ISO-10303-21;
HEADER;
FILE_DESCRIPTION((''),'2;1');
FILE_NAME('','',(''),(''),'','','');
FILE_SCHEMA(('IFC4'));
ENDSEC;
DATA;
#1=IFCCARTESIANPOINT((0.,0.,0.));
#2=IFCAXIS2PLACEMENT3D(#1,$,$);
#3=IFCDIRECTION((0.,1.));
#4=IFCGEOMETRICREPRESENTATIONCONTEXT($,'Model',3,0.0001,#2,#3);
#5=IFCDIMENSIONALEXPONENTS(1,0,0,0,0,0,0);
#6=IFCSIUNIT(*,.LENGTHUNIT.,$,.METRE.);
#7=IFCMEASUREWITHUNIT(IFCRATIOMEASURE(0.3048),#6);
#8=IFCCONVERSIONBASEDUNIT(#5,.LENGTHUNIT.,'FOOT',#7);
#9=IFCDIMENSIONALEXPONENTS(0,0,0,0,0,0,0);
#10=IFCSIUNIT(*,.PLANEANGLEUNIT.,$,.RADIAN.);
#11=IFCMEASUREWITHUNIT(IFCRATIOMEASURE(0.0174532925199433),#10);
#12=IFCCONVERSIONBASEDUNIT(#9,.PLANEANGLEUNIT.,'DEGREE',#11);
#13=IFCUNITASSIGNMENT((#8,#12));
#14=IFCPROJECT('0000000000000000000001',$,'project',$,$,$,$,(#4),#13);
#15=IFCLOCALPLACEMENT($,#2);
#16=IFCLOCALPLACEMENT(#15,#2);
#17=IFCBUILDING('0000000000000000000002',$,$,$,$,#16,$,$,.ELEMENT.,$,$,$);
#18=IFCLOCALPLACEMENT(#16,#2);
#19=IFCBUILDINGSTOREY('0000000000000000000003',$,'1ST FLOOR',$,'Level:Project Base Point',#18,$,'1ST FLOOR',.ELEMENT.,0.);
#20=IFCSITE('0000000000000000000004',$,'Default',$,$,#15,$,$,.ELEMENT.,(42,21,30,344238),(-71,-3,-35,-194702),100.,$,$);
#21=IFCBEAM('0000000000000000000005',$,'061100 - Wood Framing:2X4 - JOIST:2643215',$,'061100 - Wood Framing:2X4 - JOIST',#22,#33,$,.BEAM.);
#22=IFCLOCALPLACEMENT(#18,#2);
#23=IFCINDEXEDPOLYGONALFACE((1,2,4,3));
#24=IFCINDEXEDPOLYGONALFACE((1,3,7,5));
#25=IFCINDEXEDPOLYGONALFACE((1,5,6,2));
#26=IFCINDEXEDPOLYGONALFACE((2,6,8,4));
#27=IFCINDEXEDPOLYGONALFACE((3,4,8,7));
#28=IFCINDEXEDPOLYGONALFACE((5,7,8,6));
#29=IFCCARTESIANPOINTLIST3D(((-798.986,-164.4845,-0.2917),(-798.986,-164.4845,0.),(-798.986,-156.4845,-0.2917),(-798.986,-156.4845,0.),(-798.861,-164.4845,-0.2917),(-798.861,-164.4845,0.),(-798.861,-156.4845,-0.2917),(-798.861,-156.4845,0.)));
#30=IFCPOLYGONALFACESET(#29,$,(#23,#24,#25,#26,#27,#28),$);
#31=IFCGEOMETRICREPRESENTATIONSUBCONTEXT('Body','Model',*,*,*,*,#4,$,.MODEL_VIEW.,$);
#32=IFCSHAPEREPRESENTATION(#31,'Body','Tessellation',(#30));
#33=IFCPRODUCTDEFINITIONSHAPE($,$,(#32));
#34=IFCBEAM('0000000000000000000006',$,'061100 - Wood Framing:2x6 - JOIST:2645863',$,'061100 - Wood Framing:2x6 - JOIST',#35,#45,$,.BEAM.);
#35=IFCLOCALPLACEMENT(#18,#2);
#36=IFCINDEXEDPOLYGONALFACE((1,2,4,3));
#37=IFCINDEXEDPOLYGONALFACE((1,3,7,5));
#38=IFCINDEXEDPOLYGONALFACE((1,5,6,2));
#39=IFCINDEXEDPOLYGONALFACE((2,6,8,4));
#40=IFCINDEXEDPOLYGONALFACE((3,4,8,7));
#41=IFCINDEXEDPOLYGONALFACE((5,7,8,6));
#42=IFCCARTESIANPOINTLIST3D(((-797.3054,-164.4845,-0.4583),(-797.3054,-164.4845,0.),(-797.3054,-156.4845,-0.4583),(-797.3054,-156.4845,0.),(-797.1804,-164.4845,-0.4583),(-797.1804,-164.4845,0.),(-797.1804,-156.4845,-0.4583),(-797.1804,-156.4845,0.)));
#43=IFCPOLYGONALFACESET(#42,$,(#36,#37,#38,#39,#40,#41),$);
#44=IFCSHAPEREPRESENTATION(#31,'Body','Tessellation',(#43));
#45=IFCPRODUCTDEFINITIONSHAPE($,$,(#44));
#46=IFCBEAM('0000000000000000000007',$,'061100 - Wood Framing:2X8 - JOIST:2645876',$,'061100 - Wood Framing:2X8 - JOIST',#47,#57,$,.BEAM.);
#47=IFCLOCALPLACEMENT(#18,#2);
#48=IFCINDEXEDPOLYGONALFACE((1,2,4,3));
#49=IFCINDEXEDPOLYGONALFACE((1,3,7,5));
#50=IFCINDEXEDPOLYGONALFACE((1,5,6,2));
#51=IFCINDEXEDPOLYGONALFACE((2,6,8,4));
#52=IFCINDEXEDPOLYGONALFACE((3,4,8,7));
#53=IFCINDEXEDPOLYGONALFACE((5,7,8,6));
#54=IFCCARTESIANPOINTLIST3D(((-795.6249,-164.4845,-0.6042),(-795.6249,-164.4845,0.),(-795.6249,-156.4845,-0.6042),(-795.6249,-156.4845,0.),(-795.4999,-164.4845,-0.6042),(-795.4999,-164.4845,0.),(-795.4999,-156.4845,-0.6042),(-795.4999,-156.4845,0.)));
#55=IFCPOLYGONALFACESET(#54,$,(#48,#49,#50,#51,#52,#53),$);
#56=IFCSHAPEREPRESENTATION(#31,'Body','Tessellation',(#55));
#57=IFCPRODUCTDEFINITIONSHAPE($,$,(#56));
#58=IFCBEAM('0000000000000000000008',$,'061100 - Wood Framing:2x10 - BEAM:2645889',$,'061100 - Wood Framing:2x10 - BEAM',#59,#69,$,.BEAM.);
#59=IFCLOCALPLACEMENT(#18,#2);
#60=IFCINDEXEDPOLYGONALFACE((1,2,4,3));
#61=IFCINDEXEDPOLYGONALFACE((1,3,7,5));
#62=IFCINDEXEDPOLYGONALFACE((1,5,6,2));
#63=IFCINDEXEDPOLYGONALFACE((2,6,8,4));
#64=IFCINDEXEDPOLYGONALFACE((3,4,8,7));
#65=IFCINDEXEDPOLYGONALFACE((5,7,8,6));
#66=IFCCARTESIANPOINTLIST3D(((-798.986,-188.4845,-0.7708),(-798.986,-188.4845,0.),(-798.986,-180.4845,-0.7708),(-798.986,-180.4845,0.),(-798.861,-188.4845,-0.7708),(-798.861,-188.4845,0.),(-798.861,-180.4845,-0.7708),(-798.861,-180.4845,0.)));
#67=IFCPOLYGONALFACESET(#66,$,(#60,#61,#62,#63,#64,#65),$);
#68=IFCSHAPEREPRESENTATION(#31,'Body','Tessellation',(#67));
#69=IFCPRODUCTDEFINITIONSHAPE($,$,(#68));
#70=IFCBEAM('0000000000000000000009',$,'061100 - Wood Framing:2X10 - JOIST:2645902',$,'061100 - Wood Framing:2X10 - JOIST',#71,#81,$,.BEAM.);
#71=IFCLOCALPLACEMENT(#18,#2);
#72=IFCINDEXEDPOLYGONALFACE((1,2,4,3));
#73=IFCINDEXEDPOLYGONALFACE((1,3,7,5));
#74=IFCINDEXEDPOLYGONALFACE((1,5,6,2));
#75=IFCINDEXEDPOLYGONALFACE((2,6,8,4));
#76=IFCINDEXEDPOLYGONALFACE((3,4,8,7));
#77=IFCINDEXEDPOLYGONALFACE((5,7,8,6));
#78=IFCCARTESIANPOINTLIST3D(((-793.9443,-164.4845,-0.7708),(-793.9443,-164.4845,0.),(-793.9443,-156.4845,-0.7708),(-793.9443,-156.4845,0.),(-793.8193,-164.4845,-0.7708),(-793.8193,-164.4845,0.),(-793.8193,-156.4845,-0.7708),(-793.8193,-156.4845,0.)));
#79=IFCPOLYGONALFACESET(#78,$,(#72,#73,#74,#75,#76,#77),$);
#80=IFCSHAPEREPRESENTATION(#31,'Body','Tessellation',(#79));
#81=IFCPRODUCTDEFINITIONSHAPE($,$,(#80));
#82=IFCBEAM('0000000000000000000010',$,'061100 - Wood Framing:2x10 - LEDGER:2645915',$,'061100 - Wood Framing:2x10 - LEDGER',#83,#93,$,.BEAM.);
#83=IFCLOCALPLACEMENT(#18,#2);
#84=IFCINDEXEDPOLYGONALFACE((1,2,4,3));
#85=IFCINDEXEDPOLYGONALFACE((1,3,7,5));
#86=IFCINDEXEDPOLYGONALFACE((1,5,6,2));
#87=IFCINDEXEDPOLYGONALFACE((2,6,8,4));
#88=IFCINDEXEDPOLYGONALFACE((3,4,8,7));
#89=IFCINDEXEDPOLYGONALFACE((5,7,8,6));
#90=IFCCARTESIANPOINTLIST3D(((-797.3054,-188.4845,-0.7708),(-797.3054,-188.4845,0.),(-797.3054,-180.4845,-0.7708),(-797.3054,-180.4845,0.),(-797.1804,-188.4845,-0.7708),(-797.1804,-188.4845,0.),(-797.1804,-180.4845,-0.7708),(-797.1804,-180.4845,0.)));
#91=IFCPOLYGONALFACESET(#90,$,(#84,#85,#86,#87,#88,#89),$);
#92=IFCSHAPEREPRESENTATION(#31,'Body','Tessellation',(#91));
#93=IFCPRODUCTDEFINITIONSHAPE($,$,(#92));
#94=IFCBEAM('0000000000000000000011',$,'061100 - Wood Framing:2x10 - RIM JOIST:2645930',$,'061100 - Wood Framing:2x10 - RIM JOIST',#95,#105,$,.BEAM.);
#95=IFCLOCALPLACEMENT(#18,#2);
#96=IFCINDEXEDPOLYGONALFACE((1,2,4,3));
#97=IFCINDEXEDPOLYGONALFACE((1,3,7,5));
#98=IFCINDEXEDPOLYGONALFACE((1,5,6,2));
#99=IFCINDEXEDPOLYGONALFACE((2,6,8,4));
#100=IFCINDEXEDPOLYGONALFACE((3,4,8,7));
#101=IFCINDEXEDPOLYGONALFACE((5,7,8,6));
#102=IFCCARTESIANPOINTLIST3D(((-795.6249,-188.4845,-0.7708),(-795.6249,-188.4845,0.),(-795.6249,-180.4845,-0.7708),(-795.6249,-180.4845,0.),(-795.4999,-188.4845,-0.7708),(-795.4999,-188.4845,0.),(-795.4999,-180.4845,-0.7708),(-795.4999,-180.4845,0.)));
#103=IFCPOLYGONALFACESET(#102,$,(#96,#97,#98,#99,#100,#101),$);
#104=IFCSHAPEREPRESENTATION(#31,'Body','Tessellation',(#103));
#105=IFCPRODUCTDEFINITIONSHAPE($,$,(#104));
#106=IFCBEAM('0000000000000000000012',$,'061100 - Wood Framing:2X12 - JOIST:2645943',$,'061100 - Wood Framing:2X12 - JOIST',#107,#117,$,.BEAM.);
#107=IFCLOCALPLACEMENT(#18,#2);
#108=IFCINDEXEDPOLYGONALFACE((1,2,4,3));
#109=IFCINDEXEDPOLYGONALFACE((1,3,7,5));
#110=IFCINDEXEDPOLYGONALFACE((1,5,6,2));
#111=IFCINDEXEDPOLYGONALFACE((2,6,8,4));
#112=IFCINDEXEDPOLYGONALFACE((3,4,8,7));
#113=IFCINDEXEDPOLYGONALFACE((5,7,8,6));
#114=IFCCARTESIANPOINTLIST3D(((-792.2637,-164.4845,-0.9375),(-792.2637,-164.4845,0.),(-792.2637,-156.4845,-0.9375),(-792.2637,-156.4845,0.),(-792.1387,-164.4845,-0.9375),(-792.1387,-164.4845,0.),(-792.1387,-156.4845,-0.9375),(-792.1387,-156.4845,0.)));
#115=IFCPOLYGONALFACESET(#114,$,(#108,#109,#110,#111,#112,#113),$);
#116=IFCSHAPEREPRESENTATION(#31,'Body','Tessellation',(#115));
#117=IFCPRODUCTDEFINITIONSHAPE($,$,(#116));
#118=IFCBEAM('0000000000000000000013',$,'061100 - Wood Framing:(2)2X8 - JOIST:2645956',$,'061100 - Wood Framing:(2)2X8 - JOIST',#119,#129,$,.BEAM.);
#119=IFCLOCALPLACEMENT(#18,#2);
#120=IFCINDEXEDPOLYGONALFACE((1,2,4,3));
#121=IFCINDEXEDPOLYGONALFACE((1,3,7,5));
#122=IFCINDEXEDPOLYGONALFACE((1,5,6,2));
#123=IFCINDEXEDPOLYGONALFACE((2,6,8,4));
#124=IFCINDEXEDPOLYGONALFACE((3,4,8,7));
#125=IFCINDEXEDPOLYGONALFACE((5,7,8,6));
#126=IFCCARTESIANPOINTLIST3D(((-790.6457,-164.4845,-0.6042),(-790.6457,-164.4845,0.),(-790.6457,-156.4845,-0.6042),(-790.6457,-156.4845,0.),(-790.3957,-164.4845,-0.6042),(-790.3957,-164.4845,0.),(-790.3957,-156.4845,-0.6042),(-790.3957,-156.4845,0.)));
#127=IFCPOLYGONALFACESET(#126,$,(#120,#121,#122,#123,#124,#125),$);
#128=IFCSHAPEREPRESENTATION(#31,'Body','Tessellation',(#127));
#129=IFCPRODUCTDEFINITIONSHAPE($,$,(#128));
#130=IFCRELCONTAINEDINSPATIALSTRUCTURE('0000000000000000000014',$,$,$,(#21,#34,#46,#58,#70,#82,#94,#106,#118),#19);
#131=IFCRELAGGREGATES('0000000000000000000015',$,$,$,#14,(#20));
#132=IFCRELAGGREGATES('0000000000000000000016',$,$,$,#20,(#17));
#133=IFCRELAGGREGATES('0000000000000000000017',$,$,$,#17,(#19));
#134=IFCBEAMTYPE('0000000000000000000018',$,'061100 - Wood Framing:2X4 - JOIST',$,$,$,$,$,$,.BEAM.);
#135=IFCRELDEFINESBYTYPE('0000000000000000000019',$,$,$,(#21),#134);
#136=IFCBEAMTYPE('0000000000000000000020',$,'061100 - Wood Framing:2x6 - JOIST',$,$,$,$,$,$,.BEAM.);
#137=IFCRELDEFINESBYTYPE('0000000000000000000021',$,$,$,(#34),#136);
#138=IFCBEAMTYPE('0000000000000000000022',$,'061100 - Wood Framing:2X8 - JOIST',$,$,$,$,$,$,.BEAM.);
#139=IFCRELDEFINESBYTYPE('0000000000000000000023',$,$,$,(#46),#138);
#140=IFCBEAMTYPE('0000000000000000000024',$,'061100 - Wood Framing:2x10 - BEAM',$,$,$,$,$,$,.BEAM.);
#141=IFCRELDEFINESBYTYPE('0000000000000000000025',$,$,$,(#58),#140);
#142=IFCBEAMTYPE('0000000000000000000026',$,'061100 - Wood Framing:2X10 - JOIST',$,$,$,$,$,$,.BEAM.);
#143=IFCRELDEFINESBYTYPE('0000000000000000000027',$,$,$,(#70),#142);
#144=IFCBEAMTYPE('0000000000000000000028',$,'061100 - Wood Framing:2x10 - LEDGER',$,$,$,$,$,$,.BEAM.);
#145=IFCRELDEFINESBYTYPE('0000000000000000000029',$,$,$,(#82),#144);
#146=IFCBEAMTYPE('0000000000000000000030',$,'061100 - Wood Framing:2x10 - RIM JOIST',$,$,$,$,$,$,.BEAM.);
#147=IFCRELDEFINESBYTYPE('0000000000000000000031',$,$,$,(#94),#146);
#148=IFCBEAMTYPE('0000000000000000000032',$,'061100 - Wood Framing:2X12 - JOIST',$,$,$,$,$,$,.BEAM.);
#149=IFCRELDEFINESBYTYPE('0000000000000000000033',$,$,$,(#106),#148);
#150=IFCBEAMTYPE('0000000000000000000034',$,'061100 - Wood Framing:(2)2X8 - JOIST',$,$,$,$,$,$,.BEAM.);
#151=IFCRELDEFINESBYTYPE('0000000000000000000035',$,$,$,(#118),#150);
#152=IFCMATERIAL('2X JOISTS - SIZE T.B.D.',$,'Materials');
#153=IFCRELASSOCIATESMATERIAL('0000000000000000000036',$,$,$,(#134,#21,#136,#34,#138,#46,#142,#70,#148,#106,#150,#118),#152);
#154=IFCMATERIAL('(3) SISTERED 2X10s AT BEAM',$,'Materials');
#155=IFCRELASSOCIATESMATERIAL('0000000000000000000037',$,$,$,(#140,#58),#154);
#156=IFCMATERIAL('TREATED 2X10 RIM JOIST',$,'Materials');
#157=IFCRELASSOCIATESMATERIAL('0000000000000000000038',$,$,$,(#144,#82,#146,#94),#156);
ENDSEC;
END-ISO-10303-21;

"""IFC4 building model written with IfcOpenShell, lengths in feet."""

from ifc_helpers import new_model, entity, si_unit, converted_unit, direction, frame, frame_2d, origin, origin_2d_with_axis, place, context, subcontext, project, spatial, rectangle, extrude, source, transform, mapped, material, material_profile, profile_set, profile_usage, type_object, type_shapes, element, save


model = new_model("IFC4")

# Units and contexts
model_context = context("Model", 3, precision=0.0001, world=origin(), true_north=direction((0.0, 1.0)))
body_context = subcontext(model_context, "Body", "Model", "MODEL_VIEW")
ifc_project = project(units=[converted_unit("LENGTHUNIT", "FOOT", entity("IfcRatioMeasure", 0.3048), si_unit("LENGTHUNIT", "METRE"), dimensions=[1, 0, 0, 0, 0, 0, 0]), converted_unit("PLANEANGLEUNIT", "DEGREE", entity("IfcRatioMeasure", 0.0174532925199433), si_unit("PLANEANGLEUNIT", "RADIAN"), dimensions=[0, 0, 0, 0, 0, 0, 0])], contexts=[model_context])

# Site, building, storey
site_placement = place(None, origin())
site = spatial("IfcSite", under=ifc_project, at=site_placement, Name="Default", CompositionType="ELEMENT", RefLatitude=(42, 21, 30, 344238), RefLongitude=(-71, -3, -35, -194702), RefElevation=100.0)
building_placement = place(site_placement, origin())
building = spatial("IfcBuilding", under=site, at=building_placement, CompositionType="ELEMENT")
storey_placement = place(building_placement, origin())
storey = spatial("IfcBuildingStorey", under=building, at=storey_placement, Name="1ST FLOOR", ObjectType="Level:Project Base Point", LongName="1ST FLOOR", CompositionType="ELEMENT", Elevation=0.0)

# Beams
ifc_material_1 = material(Name="2X JOISTS - SIZE T.B.D.", Category="Materials")
ifc_material_profile_1 = material_profile(ifc_material_1, rectangle(XDim=0.2917, YDim=0.125, at=origin_2d_with_axis()), Name="2X4 - JOIST")
ifc_profile_set_1 = profile_set([ifc_material_profile_1], Name="2X4 - JOIST")
ifc_profile_usage_1 = profile_usage(ifc_profile_set_1, cardinal=8)
beam_type_1 = type_object("IfcBeamType", Name="061100 - Wood Framing:2X4 - JOIST", PredefinedType="BEAM", material=ifc_profile_set_1)
shared_shape_1 = source(origin(), body_context, "Body", "SweptSolid", [
    extrude(rectangle(XDim=0.2917, YDim=0.125, at=origin_2d_with_axis()), frame((-4.0, 0.0, 0.0), z_axis=(1.0, 0.0, 0.0), x_axis=(0.0, 0.0, -1.0)), (0.0, 0.0, 1.0), 8.0),
])
type_shapes(beam_type_1, [shared_shape_1])
beam_1_placement = place(storey_placement, frame((-798.9235, -160.4845, -0.1458), z_axis=(0.0, 0.0, 1.0), x_axis=(0.0, -1.0, 0.0)))
element("IfcBeam", 1, at=beam_1_placement, inside=storey, type_object=beam_type_1, material=ifc_profile_usage_1, Name="061100 - Wood Framing:2X4 - JOIST:2643215", ObjectType="061100 - Wood Framing:2X4 - JOIST", PredefinedType="BEAM", context=body_context, shape_type="MappedRepresentation", body=[
    mapped(shared_shape_1, transform((0.0, 0.0, 0.0), scale=1.0)),
])
ifc_material_profile_2 = material_profile(ifc_material_1, rectangle(XDim=0.4583, YDim=0.125, at=origin_2d_with_axis()), Name="2x6 - JOIST")
ifc_profile_set_2 = profile_set([ifc_material_profile_2], Name="2x6 - JOIST")
ifc_profile_usage_2 = profile_usage(ifc_profile_set_2, cardinal=8)
beam_type_2 = type_object("IfcBeamType", Name="061100 - Wood Framing:2x6 - JOIST", PredefinedType="BEAM", material=ifc_profile_set_2)
shared_shape_2 = source(origin(), body_context, "Body", "SweptSolid", [
    extrude(rectangle(XDim=0.4583, YDim=0.125, at=origin_2d_with_axis()), frame((-4.0, 0.0, 0.0), z_axis=(1.0, 0.0, 0.0), x_axis=(0.0, 0.0, -1.0)), (0.0, 0.0, 1.0), 8.0),
])
type_shapes(beam_type_2, [shared_shape_2])
beam_2_placement = place(storey_placement, frame((-797.2429, -160.4845, -0.2292), z_axis=(0.0, 0.0, 1.0), x_axis=(0.0, -1.0, 0.0)))
element("IfcBeam", 2, at=beam_2_placement, inside=storey, type_object=beam_type_2, material=ifc_profile_usage_2, Name="061100 - Wood Framing:2x6 - JOIST:2645863", ObjectType="061100 - Wood Framing:2x6 - JOIST", PredefinedType="BEAM", context=body_context, shape_type="MappedRepresentation", body=[
    mapped(shared_shape_2, transform((0.0, 0.0, 0.0), scale=1.0)),
])
ifc_material_profile_3 = material_profile(ifc_material_1, rectangle(XDim=0.6042, YDim=0.125, at=origin_2d_with_axis()), Name="2X8 - JOIST")
ifc_profile_set_3 = profile_set([ifc_material_profile_3], Name="2X8 - JOIST")
ifc_profile_usage_3 = profile_usage(ifc_profile_set_3, cardinal=8)
beam_type_3 = type_object("IfcBeamType", Name="061100 - Wood Framing:2X8 - JOIST", PredefinedType="BEAM", material=ifc_profile_set_3)
shared_shape_3 = source(origin(), body_context, "Body", "SweptSolid", [
    extrude(rectangle(XDim=0.6042, YDim=0.125, at=origin_2d_with_axis()), frame((-4.0, 0.0, 0.0), z_axis=(1.0, 0.0, 0.0), x_axis=(0.0, 0.0, -1.0)), (0.0, 0.0, 1.0), 8.0),
])
type_shapes(beam_type_3, [shared_shape_3])
beam_3_placement = place(storey_placement, frame((-795.5624, -160.4845, -0.3021), z_axis=(0.0, 0.0, 1.0), x_axis=(0.0, -1.0, 0.0)))
element("IfcBeam", 3, at=beam_3_placement, inside=storey, type_object=beam_type_3, material=ifc_profile_usage_3, Name="061100 - Wood Framing:2X8 - JOIST:2645876", ObjectType="061100 - Wood Framing:2X8 - JOIST", PredefinedType="BEAM", context=body_context, shape_type="MappedRepresentation", body=[
    mapped(shared_shape_3, transform((0.0, 0.0, 0.0), scale=1.0)),
])
ifc_material_2 = material(Name="(3) SISTERED 2X10s AT BEAM", Category="Materials")
ifc_material_profile_4 = material_profile(ifc_material_2, rectangle(XDim=0.7708, YDim=0.125, at=frame_2d((0.0, 0.0), x_axis=(1.0, 0.0))), Name="2x10 - BEAM")
ifc_profile_set_4 = profile_set([ifc_material_profile_4], Name="2x10 - BEAM")
ifc_profile_usage_4 = profile_usage(ifc_profile_set_4, cardinal=8)
beam_type_4 = type_object("IfcBeamType", Name="061100 - Wood Framing:2x10 - BEAM", PredefinedType="BEAM", material=ifc_profile_set_4)
shared_shape_4 = source(origin(), body_context, "Body", "SweptSolid", [
    extrude(rectangle(XDim=0.7708, YDim=0.125, at=frame_2d((0.0, 0.0), x_axis=(1.0, 0.0))), frame((-4.0, 0.0, 0.0), z_axis=(1.0, 0.0, 0.0), x_axis=(0.0, 0.0, -1.0)), (0.0, 0.0, 1.0), 8.0),
])
type_shapes(beam_type_4, [shared_shape_4])
beam_4_placement = place(storey_placement, frame((-798.9235, -184.4845, -0.3854), z_axis=(0.0, 0.0, 1.0), x_axis=(0.0, -1.0, 0.0)))
element("IfcBeam", 4, at=beam_4_placement, inside=storey, type_object=beam_type_4, material=ifc_profile_usage_4, Name="061100 - Wood Framing:2x10 - BEAM:2645889", ObjectType="061100 - Wood Framing:2x10 - BEAM", PredefinedType="BEAM", context=body_context, shape_type="MappedRepresentation", body=[
    mapped(shared_shape_4, transform((0.0, 0.0, 0.0), scale=1.0)),
])
ifc_material_profile_5 = material_profile(ifc_material_1, rectangle(XDim=0.7708, YDim=0.125, at=frame_2d((0.0, 0.0), x_axis=(1.0, 0.0))), Name="2X10 - JOIST")
ifc_profile_set_5 = profile_set([ifc_material_profile_5], Name="2X10 - JOIST")
ifc_profile_usage_5 = profile_usage(ifc_profile_set_5, cardinal=8)
beam_type_5 = type_object("IfcBeamType", Name="061100 - Wood Framing:2X10 - JOIST", PredefinedType="BEAM", material=ifc_profile_set_5)
shared_shape_5 = source(origin(), body_context, "Body", "SweptSolid", [
    extrude(rectangle(XDim=0.7708, YDim=0.125, at=frame_2d((0.0, 0.0), x_axis=(1.0, 0.0))), frame((-4.0, 0.0, 0.0), z_axis=(1.0, 0.0, 0.0), x_axis=(0.0, 0.0, -1.0)), (0.0, 0.0, 1.0), 8.0),
])
type_shapes(beam_type_5, [shared_shape_5])
beam_5_placement = place(storey_placement, frame((-793.8818, -160.4845, -0.3854), z_axis=(0.0, 0.0, 1.0), x_axis=(0.0, -1.0, 0.0)))
element("IfcBeam", 5, at=beam_5_placement, inside=storey, type_object=beam_type_5, material=ifc_profile_usage_5, Name="061100 - Wood Framing:2X10 - JOIST:2645902", ObjectType="061100 - Wood Framing:2X10 - JOIST", PredefinedType="BEAM", context=body_context, shape_type="MappedRepresentation", body=[
    mapped(shared_shape_5, transform((0.0, 0.0, 0.0), scale=1.0)),
])
ifc_material_3 = material(Name="TREATED 2X10 RIM JOIST", Category="Materials")
ifc_material_profile_6 = material_profile(ifc_material_3, rectangle(XDim=0.7708, YDim=0.125, at=frame_2d((0.0, 0.0), x_axis=(1.0, 0.0))), Name="2x10 - LEDGER")
ifc_profile_set_6 = profile_set([ifc_material_profile_6], Name="2x10 - LEDGER")
ifc_profile_usage_6 = profile_usage(ifc_profile_set_6, cardinal=8)
beam_type_6 = type_object("IfcBeamType", Name="061100 - Wood Framing:2x10 - LEDGER", PredefinedType="BEAM", material=ifc_profile_set_6)
shared_shape_6 = source(origin(), body_context, "Body", "SweptSolid", [
    extrude(rectangle(XDim=0.7708, YDim=0.125, at=frame_2d((0.0, 0.0), x_axis=(1.0, 0.0))), frame((-4.0, 0.0, 0.0), z_axis=(1.0, 0.0, 0.0), x_axis=(0.0, 0.0, -1.0)), (0.0, 0.0, 1.0), 8.0),
])
type_shapes(beam_type_6, [shared_shape_6])
beam_6_placement = place(storey_placement, frame((-797.2429, -184.4845, -0.3854), z_axis=(0.0, 0.0, 1.0), x_axis=(0.0, -1.0, 0.0)))
element("IfcBeam", 6, at=beam_6_placement, inside=storey, type_object=beam_type_6, material=ifc_profile_usage_6, Name="061100 - Wood Framing:2x10 - LEDGER:2645915", ObjectType="061100 - Wood Framing:2x10 - LEDGER", PredefinedType="BEAM", context=body_context, shape_type="MappedRepresentation", body=[
    mapped(shared_shape_6, transform((0.0, 0.0, 0.0), scale=1.0)),
])
ifc_material_profile_7 = material_profile(ifc_material_3, rectangle(XDim=0.7708, YDim=0.125, at=origin_2d_with_axis()), Name="2x10 - RIM JOIST")
ifc_profile_set_7 = profile_set([ifc_material_profile_7], Name="2x10 - RIM JOIST")
ifc_profile_usage_7 = profile_usage(ifc_profile_set_7, cardinal=8)
beam_type_7 = type_object("IfcBeamType", Name="061100 - Wood Framing:2x10 - RIM JOIST", PredefinedType="BEAM", material=ifc_profile_set_7)
shared_shape_7 = source(origin(), body_context, "Body", "SweptSolid", [
    extrude(rectangle(XDim=0.7708, YDim=0.125, at=frame_2d((0.0, 0.0), x_axis=(1.0, 0.0))), frame((-4.0, 0.0, 0.0), z_axis=(1.0, 0.0, 0.0), x_axis=(0.0, 0.0, -1.0)), (0.0, 0.0, 1.0), 8.0),
])
type_shapes(beam_type_7, [shared_shape_7])
beam_7_placement = place(storey_placement, frame((-795.5624, -184.4845, -0.3854), z_axis=(0.0, 0.0, 1.0), x_axis=(0.0, -1.0, 0.0)))
element("IfcBeam", 7, at=beam_7_placement, inside=storey, type_object=beam_type_7, material=ifc_profile_usage_7, Name="061100 - Wood Framing:2x10 - RIM JOIST:2645930", ObjectType="061100 - Wood Framing:2x10 - RIM JOIST", PredefinedType="BEAM", context=body_context, shape_type="MappedRepresentation", body=[
    mapped(shared_shape_7, transform((0.0, 0.0, 0.0), scale=1.0)),
])
ifc_material_profile_8 = material_profile(ifc_material_1, rectangle(XDim=0.9375, YDim=0.125, at=origin_2d_with_axis()), Name="2X12 - JOIST")
ifc_profile_set_8 = profile_set([ifc_material_profile_8], Name="2X12 - JOIST")
ifc_profile_usage_8 = profile_usage(ifc_profile_set_8, cardinal=8)
beam_type_8 = type_object("IfcBeamType", Name="061100 - Wood Framing:2X12 - JOIST", PredefinedType="BEAM", material=ifc_profile_set_8)
shared_shape_8 = source(origin(), body_context, "Body", "SweptSolid", [
    extrude(rectangle(XDim=0.9375, YDim=0.125, at=origin_2d_with_axis()), frame((-4.0, 0.0, 0.0), z_axis=(1.0, 0.0, 0.0), x_axis=(0.0, 0.0, -1.0)), (0.0, 0.0, 1.0), 8.0),
])
type_shapes(beam_type_8, [shared_shape_8])
beam_8_placement = place(storey_placement, frame((-792.2012, -160.4845, -0.4687), z_axis=(0.0, 0.0, 1.0), x_axis=(0.0, -1.0, 0.0)))
element("IfcBeam", 8, at=beam_8_placement, inside=storey, type_object=beam_type_8, material=ifc_profile_usage_8, Name="061100 - Wood Framing:2X12 - JOIST:2645943", ObjectType="061100 - Wood Framing:2X12 - JOIST", PredefinedType="BEAM", context=body_context, shape_type="MappedRepresentation", body=[
    mapped(shared_shape_8, transform((0.0, 0.0, 0.0), scale=1.0)),
])
ifc_material_profile_9 = material_profile(ifc_material_1, rectangle(XDim=0.6042, YDim=0.25, at=origin_2d_with_axis()), Name="(2)2X8 - JOIST")
ifc_profile_set_9 = profile_set([ifc_material_profile_9], Name="(2)2X8 - JOIST")
ifc_profile_usage_9 = profile_usage(ifc_profile_set_9, cardinal=8)
beam_type_9 = type_object("IfcBeamType", Name="061100 - Wood Framing:(2)2X8 - JOIST", PredefinedType="BEAM", material=ifc_profile_set_9)
shared_shape_9 = source(origin(), body_context, "Body", "SweptSolid", [
    extrude(rectangle(XDim=0.6042, YDim=0.25, at=origin_2d_with_axis()), frame((-4.0, 0.0, 0.0), z_axis=(1.0, 0.0, 0.0), x_axis=(0.0, 0.0, -1.0)), (0.0, 0.0, 1.0), 8.0),
])
type_shapes(beam_type_9, [shared_shape_9])
beam_9_placement = place(storey_placement, frame((-790.5207, -160.4845, -0.3021), z_axis=(0.0, 0.0, 1.0), x_axis=(0.0, -1.0, 0.0)))
element("IfcBeam", 9, at=beam_9_placement, inside=storey, type_object=beam_type_9, material=ifc_profile_usage_9, Name="061100 - Wood Framing:(2)2X8 - JOIST:2645956", ObjectType="061100 - Wood Framing:(2)2X8 - JOIST", PredefinedType="BEAM", context=body_context, shape_type="MappedRepresentation", body=[
    mapped(shared_shape_9, transform((0.0, 0.0, 0.0), scale=1.0)),
])

save(model, "model.ifc")
